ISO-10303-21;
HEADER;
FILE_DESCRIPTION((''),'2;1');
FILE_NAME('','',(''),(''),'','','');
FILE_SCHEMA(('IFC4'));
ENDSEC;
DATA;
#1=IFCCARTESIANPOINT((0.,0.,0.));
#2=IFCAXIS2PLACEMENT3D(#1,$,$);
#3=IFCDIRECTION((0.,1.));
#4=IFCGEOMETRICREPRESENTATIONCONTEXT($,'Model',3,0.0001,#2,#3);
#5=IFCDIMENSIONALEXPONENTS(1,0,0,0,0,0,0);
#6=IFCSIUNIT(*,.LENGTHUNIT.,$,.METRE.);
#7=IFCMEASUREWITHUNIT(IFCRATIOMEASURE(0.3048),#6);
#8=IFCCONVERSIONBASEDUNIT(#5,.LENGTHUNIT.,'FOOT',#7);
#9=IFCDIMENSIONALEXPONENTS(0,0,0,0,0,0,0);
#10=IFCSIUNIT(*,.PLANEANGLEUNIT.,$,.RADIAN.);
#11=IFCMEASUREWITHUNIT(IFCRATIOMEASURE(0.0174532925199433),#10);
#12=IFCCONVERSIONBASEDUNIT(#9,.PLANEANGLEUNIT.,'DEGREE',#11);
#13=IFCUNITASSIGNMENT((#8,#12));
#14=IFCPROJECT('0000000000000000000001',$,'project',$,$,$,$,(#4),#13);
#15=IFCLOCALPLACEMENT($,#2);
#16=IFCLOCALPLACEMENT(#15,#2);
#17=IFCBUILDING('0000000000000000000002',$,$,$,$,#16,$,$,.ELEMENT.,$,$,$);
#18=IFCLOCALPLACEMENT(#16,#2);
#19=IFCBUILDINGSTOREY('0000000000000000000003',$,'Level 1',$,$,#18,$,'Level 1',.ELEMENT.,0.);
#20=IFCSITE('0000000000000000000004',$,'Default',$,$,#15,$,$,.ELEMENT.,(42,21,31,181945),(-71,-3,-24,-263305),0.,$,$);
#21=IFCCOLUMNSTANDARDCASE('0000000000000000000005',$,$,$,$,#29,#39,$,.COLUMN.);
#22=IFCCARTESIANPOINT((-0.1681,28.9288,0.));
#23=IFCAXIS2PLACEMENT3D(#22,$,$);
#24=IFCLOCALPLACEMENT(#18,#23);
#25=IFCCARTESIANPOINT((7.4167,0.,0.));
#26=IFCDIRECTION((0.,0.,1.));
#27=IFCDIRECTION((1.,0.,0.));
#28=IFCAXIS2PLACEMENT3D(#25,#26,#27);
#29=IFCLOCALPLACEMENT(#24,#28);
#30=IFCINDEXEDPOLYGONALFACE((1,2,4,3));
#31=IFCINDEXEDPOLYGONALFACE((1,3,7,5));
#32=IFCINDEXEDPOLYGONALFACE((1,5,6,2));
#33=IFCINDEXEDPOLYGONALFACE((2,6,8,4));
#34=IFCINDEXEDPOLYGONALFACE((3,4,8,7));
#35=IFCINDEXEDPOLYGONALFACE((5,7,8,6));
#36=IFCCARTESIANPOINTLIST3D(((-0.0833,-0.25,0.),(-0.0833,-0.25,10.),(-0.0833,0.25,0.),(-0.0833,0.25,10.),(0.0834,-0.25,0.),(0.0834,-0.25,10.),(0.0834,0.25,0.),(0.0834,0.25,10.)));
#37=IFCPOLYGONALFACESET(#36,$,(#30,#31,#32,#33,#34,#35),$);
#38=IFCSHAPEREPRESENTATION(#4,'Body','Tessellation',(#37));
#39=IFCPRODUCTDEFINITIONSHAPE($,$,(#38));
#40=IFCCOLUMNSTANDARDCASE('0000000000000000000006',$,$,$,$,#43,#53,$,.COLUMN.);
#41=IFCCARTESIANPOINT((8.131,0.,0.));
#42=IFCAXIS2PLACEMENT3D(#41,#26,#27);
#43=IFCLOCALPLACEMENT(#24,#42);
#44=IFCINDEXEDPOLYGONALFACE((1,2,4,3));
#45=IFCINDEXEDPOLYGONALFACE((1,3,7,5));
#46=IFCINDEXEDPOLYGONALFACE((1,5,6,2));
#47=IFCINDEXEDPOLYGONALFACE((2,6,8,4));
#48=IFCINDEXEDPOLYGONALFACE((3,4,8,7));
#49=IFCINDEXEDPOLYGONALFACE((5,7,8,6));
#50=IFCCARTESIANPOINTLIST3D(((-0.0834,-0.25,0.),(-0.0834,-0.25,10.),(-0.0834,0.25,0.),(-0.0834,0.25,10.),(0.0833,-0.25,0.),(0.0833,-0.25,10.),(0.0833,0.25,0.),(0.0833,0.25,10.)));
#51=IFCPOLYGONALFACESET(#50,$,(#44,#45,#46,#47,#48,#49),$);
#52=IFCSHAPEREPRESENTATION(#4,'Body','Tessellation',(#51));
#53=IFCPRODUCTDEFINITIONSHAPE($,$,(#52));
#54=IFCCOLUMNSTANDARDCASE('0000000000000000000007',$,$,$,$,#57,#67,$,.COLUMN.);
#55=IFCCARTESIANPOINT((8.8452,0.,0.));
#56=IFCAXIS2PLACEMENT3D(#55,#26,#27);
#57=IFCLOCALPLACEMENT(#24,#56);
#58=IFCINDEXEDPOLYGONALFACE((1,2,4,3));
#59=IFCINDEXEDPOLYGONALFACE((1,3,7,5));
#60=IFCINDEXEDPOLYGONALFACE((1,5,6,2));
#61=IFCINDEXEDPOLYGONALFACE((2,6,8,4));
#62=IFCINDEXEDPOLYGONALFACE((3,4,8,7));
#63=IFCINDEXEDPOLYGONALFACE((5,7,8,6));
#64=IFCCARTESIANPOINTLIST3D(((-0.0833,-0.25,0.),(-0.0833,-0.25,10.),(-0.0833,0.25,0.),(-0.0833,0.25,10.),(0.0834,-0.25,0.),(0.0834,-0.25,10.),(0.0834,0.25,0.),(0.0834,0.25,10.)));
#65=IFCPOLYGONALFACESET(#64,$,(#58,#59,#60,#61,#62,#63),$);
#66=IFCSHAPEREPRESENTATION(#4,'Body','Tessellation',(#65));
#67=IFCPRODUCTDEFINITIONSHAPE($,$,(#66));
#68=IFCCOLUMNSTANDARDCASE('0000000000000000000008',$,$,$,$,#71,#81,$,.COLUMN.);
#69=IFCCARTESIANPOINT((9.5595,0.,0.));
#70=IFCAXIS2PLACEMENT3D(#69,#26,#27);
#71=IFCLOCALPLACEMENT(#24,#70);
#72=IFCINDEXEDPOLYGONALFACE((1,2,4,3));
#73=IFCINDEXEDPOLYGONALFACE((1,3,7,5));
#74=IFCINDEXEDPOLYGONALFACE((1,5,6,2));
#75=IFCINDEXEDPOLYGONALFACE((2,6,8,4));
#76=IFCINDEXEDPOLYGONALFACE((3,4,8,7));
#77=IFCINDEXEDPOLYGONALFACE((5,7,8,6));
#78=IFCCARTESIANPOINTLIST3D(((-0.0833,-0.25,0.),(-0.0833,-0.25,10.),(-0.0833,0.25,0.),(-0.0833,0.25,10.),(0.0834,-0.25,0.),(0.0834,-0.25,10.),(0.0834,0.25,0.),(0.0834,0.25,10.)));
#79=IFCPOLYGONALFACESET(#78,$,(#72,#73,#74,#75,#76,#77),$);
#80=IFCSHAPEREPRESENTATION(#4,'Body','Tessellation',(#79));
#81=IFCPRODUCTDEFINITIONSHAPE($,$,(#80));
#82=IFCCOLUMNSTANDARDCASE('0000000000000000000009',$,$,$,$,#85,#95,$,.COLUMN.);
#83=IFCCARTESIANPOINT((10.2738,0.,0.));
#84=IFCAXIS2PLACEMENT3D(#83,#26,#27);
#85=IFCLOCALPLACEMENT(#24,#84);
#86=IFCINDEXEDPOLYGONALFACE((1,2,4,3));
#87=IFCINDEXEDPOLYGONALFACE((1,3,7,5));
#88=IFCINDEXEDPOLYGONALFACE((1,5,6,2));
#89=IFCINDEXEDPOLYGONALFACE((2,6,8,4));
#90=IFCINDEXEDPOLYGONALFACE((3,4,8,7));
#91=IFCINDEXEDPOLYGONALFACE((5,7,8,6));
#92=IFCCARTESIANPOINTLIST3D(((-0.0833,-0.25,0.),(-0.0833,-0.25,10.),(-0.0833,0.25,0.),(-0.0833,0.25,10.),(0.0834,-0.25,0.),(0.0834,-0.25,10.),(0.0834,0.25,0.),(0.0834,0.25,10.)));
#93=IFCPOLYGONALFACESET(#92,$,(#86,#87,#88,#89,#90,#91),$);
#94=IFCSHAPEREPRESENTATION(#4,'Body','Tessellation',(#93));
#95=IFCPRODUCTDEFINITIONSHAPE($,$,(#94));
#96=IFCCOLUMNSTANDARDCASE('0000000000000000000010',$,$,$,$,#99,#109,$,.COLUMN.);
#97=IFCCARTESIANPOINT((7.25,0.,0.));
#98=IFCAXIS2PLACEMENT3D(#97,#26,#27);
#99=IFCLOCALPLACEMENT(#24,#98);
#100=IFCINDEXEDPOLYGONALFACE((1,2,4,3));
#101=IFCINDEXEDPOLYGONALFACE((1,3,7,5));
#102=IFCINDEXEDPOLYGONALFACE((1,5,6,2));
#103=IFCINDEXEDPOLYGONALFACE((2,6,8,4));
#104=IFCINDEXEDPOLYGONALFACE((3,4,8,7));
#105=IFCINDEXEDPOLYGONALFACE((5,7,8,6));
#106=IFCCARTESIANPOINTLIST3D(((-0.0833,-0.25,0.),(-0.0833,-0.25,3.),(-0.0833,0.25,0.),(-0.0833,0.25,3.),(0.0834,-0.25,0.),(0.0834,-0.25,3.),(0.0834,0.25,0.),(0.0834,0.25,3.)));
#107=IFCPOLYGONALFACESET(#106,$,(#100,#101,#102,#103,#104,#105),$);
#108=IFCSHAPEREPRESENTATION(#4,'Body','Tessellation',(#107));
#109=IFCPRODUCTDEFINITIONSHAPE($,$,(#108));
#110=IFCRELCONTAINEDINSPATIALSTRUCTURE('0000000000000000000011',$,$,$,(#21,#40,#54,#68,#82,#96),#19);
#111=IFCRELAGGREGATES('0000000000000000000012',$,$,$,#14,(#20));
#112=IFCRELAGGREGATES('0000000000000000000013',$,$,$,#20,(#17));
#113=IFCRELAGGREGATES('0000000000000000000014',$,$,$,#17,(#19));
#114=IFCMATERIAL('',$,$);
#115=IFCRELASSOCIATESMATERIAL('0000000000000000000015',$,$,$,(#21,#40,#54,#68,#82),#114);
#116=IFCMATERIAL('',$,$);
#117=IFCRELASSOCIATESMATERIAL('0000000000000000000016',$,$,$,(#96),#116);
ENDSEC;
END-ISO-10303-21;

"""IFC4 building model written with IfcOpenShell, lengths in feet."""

from ifc_helpers import new_model, entity, si_unit, converted_unit, direction, frame, origin, place, context, project, spatial, rectangle, extrude, material, element, save


model = new_model("IFC4")

# Units and contexts
model_context = context("Model", 3, precision=0.0001, world=origin(), true_north=direction((0.0, 1.0)))
ifc_project = project(units=[converted_unit("LENGTHUNIT", "FOOT", entity("IfcRatioMeasure", 0.3048), si_unit("LENGTHUNIT", "METRE"), dimensions=[1, 0, 0, 0, 0, 0, 0]), converted_unit("PLANEANGLEUNIT", "DEGREE", entity("IfcRatioMeasure", 0.0174532925199433), si_unit("PLANEANGLEUNIT", "RADIAN"), dimensions=[0, 0, 0, 0, 0, 0, 0])], contexts=[model_context])

# Site, building, storey
site_placement = place(None, origin())
site = spatial("IfcSite", under=ifc_project, at=site_placement, Name="Default", CompositionType="ELEMENT", RefLatitude=(42, 21, 31, 181945), RefLongitude=(-71, -3, -24, -263305), RefElevation=0.0)
building_placement = place(site_placement, origin())
building = spatial("IfcBuilding", under=site, at=building_placement, CompositionType="ELEMENT")
storey_placement = place(building_placement, origin())
storey = spatial("IfcBuildingStorey", under=building, at=storey_placement, Name="Level 1", LongName="Level 1", CompositionType="ELEMENT", Elevation=0.0)

# Columns
ifc_material_1 = material(Name="")
placement = place(storey_placement, frame((-0.1681, 28.9288, 0.0)))
for number, where, z_axis, x_axis in (
    (1, (7.4167, 0.0, 0.0), (0.0, 0.0, 1.0), (1.0, 0.0, 0.0)),
    (2, (8.131, 0.0, 0.0), (0.0, 0.0, 1.0), (1.0, 0.0, 0.0)),
    (3, (8.8452, 0.0, 0.0), (0.0, 0.0, 1.0), (1.0, 0.0, 0.0)),
    (4, (9.5595, 0.0, 0.0), (0.0, 0.0, 1.0), (1.0, 0.0, 0.0)),
    (5, (10.2738, 0.0, 0.0), (0.0, 0.0, 1.0), (1.0, 0.0, 0.0)),
):
    element("IfcColumnStandardCase", number, at=place(placement, frame(where, z_axis=z_axis, x_axis=x_axis)), inside=storey, material=ifc_material_1, PredefinedType="COLUMN", context=model_context, shape_type="SweptSolid", body=[
        extrude(rectangle(XDim=0.1667, YDim=0.5), origin(), (0.0, 0.0, 1.0), 10.0),
    ])
ifc_material_2 = material(Name="")
for number, where, z_axis, x_axis in (
    (6, (7.25, 0.0, 0.0), (0.0, 0.0, 1.0), (1.0, 0.0, 0.0)),
):
    element("IfcColumnStandardCase", number, at=place(placement, frame(where, z_axis=z_axis, x_axis=x_axis)), inside=storey, material=ifc_material_2, PredefinedType="COLUMN", context=model_context, shape_type="SweptSolid", body=[
        extrude(rectangle(XDim=0.1667, YDim=0.5), origin(), (0.0, 0.0, 1.0), 3.0),
    ])

save(model, "model.ifc")
